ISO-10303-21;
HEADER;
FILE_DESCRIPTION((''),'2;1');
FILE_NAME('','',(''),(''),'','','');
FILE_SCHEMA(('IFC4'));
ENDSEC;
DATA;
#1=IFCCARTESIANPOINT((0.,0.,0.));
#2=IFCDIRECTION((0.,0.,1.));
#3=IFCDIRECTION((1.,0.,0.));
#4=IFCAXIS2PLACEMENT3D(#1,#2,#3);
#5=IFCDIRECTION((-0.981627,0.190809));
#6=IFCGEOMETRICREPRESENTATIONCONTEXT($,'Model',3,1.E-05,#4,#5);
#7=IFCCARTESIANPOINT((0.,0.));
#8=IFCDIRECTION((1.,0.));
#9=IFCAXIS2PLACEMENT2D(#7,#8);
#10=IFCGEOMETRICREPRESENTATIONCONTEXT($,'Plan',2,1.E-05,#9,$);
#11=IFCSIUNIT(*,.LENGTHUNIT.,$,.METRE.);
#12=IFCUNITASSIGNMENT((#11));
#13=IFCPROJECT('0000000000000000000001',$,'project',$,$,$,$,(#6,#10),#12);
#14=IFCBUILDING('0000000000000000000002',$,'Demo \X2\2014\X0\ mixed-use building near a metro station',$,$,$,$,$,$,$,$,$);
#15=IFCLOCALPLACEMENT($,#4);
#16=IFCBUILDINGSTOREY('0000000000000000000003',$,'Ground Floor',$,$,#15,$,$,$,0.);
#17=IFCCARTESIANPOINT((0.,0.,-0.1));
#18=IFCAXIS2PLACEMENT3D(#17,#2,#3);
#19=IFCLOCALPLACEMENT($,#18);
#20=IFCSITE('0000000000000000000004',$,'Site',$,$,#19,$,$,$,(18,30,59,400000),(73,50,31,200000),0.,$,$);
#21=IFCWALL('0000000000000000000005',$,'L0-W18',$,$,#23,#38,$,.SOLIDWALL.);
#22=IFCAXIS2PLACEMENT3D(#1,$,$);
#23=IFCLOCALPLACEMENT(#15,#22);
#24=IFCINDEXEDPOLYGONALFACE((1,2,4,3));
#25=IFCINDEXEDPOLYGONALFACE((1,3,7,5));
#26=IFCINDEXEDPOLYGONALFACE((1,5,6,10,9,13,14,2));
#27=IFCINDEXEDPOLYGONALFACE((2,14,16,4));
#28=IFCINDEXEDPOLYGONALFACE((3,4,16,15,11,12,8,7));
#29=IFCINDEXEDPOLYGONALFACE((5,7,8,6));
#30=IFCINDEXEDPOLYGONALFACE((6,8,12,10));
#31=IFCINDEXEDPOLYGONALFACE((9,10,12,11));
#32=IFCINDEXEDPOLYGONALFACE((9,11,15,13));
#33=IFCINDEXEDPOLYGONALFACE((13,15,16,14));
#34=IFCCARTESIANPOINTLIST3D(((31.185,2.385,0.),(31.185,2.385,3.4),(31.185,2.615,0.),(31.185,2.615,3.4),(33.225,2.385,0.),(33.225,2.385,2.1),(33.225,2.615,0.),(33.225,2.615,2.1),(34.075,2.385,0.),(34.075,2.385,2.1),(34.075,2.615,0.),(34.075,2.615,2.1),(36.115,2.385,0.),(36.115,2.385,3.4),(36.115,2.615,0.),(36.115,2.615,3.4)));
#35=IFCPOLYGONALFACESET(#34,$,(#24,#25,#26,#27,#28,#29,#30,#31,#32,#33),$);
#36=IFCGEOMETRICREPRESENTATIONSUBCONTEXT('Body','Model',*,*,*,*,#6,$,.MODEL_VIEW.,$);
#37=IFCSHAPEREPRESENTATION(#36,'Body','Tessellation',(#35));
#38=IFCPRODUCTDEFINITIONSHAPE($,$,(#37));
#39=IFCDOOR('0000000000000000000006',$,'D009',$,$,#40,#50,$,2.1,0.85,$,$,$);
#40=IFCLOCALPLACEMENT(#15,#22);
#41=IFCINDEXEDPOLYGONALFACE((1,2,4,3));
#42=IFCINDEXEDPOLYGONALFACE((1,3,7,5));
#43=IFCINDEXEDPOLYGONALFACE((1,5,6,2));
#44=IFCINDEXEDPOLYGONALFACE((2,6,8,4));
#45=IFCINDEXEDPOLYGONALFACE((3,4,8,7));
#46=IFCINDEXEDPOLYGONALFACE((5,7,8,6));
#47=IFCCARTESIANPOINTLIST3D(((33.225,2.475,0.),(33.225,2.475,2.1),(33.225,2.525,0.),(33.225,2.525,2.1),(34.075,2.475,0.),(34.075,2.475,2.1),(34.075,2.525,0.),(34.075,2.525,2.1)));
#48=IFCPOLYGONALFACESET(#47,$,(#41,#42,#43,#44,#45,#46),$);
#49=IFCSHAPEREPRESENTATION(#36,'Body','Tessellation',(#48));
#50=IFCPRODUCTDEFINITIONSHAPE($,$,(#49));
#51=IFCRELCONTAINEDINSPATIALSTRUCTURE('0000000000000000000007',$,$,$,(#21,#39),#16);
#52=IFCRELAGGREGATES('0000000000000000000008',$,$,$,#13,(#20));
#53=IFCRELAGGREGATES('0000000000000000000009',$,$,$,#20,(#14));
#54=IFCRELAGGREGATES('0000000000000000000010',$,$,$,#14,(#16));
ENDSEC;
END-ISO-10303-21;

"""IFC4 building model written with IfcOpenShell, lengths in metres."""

from ifc_helpers import new_model, si_unit, direction, frame, origin_with_axes, origin_2d_with_axis, place, context, subcontext, project, spatial, line, indexed_curve, outline, extrude, element, fill, save


model = new_model("IFC4")

# Units and contexts
model_context = context("Model", 3, precision=1e-05, world=origin_with_axes(), true_north=direction((-0.981627, 0.190809)))
plan_context = context("Plan", 2, precision=1e-05, world=origin_2d_with_axis())
body_context = subcontext(model_context, "Body", "Model", "MODEL_VIEW")
ifc_project = project(units=[si_unit("LENGTHUNIT", "METRE")], contexts=[model_context, plan_context])

# Site, building, storey
site_placement = place(None, frame((0.0, 0.0, -0.1), z_axis=(0.0, 0.0, 1.0), x_axis=(1.0, 0.0, 0.0)))
site = spatial("IfcSite", under=ifc_project, at=site_placement, Name="Site", RefLatitude=(18, 30, 59, 400000), RefLongitude=(73, 50, 31, 200000), RefElevation=0.0)
building = spatial("IfcBuilding", under=site, Name="Demo — mixed-use building near a metro station")
storey_placement = place(None, origin_with_axes())
storey = spatial("IfcBuildingStorey", under=building, at=storey_placement, Name="Ground Floor", Elevation=0.0)

# Wall, opening, door
wall_1_placement = place(storey_placement, origin_with_axes())
wall_1 = element("IfcWall", 1, at=wall_1_placement, inside=storey, Name="L0-W18", PredefinedType="SOLIDWALL", context=body_context, shape_type="SweptSolid", body=[
    extrude(outline(indexed_curve([(31.185, 2.615), (36.115, 2.615), (36.115, 2.385), (31.185, 2.385)], segments=[line(1, 2, 3, 4, 1)])), origin_with_axes(), (0.0, 0.0, 1.0), 3.4),
])
opening_1_placement = place(wall_1_placement, origin_with_axes())
opening_1 = element("IfcOpeningElement", 2, at=opening_1_placement, cuts=wall_1, context=body_context, shape_type="SweptSolid", body=[
    extrude(outline(indexed_curve([(33.225, 2.665), (34.075, 2.665), (34.075, 2.335), (33.225, 2.335)], segments=[line(1, 2, 3, 4, 1)])), origin_with_axes(), (0.0, 0.0, 1.0), 2.1),
])
door_1_placement = place(storey_placement, origin_with_axes())
door_1 = element("IfcDoor", 3, at=door_1_placement, inside=storey, Name="D009", OverallHeight=2.1, OverallWidth=0.85, context=body_context, shape_type="SweptSolid", body=[
    extrude(outline(indexed_curve([(33.225, 2.525), (34.075, 2.525), (34.075, 2.475), (33.225, 2.475)], segments=[line(1, 2, 3, 4, 1)])), origin_with_axes(), (0.0, 0.0, 1.0), 2.1),
])
fill(opening_1, door_1)

save(model, "model.ifc")
